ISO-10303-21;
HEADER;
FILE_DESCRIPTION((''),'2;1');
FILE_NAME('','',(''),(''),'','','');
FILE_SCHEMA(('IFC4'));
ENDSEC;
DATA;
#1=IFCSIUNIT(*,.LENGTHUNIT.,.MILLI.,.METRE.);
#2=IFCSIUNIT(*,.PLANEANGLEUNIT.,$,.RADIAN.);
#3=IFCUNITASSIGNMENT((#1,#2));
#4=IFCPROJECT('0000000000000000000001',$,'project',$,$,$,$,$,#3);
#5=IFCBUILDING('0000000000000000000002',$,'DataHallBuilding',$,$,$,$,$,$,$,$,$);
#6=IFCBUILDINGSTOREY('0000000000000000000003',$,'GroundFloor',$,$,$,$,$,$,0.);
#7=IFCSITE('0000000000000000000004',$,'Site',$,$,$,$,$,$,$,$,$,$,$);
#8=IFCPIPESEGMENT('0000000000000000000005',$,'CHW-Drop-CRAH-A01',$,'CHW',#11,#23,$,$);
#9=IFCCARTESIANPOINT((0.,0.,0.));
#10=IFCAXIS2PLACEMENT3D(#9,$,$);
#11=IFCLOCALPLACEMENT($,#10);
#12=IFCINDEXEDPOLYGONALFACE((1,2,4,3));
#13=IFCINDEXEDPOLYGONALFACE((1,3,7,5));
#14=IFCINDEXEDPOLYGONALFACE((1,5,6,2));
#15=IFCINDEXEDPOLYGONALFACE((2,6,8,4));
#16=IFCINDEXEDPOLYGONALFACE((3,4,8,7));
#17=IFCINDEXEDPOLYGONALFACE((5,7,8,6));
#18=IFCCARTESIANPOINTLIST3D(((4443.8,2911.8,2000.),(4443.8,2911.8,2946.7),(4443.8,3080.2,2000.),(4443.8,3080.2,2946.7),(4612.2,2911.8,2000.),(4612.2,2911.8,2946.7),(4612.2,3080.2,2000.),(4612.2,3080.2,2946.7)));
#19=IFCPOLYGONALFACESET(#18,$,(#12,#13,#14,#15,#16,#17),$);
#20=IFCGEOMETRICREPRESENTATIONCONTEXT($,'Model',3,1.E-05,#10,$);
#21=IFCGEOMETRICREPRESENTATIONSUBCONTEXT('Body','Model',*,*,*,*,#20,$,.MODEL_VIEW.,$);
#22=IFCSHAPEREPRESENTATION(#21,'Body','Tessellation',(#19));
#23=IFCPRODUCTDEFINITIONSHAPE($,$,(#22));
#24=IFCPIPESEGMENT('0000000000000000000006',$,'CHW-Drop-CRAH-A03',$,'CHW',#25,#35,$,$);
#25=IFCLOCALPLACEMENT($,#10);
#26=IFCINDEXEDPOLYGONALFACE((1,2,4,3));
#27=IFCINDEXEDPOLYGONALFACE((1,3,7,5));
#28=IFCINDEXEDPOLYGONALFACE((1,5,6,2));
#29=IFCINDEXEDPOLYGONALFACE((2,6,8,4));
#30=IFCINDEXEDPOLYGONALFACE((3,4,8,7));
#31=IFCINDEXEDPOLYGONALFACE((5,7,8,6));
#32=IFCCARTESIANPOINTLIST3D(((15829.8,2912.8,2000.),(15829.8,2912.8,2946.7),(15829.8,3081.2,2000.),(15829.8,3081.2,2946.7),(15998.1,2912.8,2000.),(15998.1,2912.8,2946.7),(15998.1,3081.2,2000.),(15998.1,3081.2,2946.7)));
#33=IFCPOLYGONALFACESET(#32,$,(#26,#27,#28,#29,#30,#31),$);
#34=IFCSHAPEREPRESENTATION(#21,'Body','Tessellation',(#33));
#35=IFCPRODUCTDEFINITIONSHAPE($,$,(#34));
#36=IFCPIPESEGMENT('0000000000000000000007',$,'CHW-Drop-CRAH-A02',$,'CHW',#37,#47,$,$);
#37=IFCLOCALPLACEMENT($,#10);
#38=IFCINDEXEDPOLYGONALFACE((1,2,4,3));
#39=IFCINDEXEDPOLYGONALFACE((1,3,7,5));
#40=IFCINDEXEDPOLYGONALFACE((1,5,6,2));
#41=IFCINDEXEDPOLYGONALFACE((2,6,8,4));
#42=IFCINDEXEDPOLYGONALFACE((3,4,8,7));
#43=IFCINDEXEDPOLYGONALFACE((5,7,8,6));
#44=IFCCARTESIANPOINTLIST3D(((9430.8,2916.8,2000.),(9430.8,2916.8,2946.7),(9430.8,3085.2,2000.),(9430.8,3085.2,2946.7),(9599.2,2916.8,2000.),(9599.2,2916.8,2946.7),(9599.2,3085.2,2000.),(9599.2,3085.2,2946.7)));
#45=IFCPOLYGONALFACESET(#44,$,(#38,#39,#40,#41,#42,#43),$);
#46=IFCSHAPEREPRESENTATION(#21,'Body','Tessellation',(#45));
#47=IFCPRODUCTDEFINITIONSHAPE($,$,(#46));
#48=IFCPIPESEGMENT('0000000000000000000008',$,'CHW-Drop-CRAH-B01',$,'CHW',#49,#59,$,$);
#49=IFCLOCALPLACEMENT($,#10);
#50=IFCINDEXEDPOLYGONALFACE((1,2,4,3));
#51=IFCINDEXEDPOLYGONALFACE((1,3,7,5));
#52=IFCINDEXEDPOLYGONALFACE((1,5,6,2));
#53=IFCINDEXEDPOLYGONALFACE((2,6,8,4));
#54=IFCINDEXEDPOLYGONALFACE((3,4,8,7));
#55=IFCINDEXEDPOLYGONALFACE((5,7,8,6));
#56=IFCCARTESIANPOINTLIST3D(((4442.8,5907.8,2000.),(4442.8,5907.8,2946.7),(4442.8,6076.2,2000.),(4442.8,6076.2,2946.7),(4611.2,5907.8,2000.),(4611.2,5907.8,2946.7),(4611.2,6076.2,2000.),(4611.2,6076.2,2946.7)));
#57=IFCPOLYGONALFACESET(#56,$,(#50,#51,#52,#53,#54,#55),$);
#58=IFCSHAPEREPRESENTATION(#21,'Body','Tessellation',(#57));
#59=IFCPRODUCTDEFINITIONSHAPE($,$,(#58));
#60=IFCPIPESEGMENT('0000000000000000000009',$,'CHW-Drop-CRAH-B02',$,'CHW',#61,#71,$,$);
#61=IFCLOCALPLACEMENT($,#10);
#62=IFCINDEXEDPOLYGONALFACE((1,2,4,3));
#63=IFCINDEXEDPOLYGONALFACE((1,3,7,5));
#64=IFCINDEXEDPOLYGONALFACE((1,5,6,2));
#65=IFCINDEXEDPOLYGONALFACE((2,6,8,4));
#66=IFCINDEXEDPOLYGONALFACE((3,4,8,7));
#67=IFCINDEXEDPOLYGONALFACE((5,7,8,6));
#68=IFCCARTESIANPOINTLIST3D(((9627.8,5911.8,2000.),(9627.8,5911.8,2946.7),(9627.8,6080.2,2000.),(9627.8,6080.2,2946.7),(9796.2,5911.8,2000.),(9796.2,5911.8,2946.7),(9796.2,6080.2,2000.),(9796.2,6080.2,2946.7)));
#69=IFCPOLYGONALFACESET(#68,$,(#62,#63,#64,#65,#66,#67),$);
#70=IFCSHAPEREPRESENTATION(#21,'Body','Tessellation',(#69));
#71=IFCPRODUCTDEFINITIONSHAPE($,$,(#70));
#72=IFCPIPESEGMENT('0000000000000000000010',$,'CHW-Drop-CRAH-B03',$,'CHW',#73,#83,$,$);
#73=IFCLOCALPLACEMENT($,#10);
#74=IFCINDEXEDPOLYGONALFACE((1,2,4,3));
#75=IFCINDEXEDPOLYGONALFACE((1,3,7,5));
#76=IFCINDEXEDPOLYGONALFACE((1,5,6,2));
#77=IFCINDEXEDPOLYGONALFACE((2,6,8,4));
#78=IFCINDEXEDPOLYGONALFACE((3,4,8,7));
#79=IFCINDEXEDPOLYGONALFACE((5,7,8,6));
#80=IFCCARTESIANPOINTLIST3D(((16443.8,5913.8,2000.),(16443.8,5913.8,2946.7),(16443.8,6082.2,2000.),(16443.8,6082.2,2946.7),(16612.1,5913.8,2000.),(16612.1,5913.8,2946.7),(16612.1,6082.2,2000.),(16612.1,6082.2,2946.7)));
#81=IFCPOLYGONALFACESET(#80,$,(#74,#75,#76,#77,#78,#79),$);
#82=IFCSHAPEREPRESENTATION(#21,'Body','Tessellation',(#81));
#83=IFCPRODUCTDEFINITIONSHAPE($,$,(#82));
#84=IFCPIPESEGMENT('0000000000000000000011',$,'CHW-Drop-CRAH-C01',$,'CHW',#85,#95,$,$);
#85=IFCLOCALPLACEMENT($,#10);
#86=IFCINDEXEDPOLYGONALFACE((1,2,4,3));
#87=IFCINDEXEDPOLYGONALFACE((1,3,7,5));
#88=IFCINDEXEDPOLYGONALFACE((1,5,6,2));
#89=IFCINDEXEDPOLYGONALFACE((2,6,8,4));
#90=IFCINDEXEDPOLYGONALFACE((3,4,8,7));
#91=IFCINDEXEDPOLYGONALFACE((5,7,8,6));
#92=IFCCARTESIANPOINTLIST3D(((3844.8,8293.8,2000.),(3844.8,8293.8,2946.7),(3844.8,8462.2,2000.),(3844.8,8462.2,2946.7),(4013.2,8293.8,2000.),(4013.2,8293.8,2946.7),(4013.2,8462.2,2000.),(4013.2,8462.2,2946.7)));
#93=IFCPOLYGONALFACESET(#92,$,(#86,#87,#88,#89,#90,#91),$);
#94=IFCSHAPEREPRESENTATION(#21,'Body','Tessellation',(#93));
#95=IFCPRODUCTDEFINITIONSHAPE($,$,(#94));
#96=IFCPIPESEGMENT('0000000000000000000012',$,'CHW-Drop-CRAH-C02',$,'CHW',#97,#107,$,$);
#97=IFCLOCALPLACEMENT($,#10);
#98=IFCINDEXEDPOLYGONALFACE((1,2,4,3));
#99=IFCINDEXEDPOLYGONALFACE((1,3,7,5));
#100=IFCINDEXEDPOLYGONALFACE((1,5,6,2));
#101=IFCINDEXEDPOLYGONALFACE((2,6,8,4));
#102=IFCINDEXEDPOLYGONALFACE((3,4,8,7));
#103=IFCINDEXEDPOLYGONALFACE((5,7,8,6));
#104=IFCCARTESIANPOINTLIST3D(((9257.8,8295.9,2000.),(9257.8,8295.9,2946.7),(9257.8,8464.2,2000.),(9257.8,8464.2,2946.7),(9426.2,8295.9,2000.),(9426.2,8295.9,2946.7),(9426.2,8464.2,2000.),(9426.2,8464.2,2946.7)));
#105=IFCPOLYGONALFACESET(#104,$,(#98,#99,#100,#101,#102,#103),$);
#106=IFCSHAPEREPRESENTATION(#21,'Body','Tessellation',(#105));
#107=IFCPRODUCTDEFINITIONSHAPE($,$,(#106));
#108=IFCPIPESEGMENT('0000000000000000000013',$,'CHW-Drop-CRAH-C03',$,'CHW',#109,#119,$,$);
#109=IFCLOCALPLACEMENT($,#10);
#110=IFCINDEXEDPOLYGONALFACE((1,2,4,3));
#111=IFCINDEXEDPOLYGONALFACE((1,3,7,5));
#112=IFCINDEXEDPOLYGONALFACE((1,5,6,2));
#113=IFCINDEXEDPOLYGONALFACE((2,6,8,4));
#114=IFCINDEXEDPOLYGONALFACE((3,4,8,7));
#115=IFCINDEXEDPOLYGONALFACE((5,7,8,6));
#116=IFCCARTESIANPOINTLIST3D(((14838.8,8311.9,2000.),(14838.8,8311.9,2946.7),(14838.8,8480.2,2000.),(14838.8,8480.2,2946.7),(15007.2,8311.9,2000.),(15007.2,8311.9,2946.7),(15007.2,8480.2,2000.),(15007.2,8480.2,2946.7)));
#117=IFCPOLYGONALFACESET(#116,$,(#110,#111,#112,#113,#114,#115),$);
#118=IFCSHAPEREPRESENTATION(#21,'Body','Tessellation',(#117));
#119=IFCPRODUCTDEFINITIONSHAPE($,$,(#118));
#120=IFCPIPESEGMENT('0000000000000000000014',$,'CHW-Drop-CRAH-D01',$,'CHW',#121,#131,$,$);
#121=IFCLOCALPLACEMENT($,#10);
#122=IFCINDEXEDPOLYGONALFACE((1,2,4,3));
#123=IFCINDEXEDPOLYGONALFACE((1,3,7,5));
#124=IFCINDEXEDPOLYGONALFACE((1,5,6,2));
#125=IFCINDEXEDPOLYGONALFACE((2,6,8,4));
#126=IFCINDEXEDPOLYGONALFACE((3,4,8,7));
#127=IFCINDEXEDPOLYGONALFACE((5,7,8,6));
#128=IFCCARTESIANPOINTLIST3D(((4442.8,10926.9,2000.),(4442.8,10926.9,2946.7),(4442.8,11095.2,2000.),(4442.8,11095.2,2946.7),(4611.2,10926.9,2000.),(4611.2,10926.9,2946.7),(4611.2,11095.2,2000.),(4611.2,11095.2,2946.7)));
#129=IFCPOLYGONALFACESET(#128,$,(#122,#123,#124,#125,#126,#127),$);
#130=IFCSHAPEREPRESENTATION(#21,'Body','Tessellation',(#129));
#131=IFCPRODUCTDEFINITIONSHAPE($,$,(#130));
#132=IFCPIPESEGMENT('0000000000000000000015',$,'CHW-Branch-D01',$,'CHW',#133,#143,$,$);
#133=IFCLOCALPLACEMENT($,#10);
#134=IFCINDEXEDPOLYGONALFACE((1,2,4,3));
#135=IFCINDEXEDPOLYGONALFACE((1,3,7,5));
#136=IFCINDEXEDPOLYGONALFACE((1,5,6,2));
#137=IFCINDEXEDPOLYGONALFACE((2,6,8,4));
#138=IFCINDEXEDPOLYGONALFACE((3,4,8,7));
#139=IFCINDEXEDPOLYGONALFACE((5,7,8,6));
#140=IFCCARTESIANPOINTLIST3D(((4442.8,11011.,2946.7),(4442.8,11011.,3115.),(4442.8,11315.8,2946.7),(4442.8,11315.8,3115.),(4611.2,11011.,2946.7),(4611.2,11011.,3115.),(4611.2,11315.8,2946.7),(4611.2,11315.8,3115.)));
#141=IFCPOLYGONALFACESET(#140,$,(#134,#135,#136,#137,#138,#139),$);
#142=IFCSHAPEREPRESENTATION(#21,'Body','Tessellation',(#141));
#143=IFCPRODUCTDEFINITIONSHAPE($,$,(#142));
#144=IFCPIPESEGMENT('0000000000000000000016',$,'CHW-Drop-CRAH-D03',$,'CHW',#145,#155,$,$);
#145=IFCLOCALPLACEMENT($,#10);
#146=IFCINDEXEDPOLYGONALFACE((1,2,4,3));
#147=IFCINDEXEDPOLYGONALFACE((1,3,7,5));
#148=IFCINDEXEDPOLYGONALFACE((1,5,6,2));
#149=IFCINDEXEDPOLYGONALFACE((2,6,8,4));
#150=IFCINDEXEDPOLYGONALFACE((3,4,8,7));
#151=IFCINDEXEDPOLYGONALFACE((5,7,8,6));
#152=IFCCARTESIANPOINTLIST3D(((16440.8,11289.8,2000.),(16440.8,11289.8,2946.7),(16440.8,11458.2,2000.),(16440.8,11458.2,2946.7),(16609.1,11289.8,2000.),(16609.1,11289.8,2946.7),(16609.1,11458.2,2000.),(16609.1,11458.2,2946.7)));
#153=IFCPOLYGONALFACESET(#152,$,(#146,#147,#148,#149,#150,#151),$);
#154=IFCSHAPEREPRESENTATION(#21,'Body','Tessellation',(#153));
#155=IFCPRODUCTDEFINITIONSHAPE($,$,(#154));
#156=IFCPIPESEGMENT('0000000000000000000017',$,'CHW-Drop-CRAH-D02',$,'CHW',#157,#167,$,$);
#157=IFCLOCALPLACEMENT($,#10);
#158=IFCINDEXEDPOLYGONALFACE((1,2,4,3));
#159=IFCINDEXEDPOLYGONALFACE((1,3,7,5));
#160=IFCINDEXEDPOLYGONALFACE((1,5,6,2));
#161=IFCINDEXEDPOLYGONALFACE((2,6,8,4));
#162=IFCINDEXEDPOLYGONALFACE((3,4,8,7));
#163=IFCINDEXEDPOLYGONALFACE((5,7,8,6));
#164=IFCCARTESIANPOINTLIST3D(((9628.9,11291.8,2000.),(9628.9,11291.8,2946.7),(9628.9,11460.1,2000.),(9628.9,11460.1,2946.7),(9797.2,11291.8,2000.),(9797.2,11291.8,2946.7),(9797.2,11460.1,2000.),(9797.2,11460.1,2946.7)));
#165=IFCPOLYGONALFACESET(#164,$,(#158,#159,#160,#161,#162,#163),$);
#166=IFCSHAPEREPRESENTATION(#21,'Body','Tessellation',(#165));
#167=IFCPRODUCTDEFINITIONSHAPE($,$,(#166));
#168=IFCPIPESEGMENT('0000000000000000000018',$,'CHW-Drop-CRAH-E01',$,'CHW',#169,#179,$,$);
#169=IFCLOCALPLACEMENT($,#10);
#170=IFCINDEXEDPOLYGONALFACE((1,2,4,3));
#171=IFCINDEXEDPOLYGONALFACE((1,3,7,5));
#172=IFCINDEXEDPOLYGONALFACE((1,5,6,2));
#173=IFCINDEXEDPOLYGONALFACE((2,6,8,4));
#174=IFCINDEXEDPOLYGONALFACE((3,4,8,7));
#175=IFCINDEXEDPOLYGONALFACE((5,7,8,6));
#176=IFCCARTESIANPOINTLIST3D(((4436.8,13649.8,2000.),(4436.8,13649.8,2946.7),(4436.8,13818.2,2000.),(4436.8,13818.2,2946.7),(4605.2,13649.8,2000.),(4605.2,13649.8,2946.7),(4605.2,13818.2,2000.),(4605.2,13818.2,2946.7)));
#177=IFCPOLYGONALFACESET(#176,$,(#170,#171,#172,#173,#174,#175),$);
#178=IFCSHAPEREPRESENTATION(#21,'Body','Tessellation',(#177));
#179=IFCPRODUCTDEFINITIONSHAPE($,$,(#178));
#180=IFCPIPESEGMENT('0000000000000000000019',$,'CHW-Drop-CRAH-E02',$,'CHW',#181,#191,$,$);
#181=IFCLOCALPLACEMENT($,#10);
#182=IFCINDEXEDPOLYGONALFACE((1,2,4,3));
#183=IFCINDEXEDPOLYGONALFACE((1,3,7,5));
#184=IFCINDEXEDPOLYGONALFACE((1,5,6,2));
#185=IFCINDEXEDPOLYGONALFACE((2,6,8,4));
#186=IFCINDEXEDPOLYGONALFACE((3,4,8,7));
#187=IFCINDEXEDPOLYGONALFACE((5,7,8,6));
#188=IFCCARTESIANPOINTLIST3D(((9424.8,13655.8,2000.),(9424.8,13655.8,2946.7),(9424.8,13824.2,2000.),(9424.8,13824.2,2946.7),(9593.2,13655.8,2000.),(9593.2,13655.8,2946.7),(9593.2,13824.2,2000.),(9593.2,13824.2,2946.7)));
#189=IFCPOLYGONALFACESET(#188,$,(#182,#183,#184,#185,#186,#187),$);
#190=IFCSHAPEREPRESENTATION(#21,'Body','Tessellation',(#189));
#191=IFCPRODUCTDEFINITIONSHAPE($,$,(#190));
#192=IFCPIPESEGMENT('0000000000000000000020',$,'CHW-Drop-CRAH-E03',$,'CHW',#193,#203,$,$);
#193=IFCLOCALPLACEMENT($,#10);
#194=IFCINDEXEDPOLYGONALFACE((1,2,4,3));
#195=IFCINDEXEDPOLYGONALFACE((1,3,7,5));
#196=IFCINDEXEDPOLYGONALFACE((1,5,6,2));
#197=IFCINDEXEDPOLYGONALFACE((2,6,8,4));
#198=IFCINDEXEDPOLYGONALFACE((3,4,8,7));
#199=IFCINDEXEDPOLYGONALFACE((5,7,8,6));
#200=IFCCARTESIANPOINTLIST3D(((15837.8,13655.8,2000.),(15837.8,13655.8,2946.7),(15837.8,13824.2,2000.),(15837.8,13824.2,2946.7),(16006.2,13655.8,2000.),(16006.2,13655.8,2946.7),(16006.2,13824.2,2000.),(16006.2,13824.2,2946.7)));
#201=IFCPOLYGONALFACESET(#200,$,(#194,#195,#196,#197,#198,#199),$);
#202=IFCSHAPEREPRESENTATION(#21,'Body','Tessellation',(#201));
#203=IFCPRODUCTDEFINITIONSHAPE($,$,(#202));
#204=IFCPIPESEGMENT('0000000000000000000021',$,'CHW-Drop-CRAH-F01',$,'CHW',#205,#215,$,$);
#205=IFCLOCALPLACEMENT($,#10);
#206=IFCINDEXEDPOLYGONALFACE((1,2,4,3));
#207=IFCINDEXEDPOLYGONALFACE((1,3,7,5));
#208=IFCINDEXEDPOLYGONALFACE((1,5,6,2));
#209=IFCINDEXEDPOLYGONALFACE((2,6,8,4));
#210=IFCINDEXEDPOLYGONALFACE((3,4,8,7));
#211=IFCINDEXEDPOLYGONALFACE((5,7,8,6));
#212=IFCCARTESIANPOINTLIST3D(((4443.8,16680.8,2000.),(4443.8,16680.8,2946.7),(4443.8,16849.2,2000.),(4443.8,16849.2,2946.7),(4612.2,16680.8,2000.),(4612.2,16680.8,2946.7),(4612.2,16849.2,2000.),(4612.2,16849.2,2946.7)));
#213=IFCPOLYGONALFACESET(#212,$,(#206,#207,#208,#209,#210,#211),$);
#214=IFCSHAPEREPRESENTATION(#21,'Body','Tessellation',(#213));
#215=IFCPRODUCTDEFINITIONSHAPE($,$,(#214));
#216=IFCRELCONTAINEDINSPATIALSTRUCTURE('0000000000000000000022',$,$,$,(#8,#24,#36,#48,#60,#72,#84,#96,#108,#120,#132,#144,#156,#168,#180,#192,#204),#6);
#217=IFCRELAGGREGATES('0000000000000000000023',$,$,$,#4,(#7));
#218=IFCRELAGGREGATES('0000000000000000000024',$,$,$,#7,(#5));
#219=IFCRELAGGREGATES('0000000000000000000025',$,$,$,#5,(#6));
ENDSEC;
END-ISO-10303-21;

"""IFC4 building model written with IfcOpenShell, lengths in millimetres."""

from ifc_helpers import new_model, si_unit, frame, origin, place, context, subcontext, project, spatial, rectangle, extrude, element, save


model = new_model("IFC4")

# Units and contexts
model_context = context("Model", 3, precision=1e-05, world=origin())
body_context = subcontext(model_context, "Body", "Model", "MODEL_VIEW")
ifc_project = project(units=[si_unit("LENGTHUNIT", "METRE", prefix="MILLI"), si_unit("PLANEANGLEUNIT", "RADIAN")])

# Site, building, storey
site = spatial("IfcSite", under=ifc_project, Name="Site")
building = spatial("IfcBuilding", under=site, Name="DataHallBuilding")
storey = spatial("IfcBuildingStorey", under=building, Name="GroundFloor", Elevation=0.0)

# Pipe segments
pipe_segment_1_placement = place(None, origin())
element("IfcPipeSegment", 1, at=pipe_segment_1_placement, inside=storey, Name="CHW-Drop-CRAH-A01", ObjectType="CHW", context=body_context, shape_type="SweptSolid", body=[
    extrude(rectangle(XDim=168.3, YDim=168.3), frame((4528.0, 2996.0, 2000.0), z_axis=(0.0, 0.0, 1.0), x_axis=(1.0, 0.0, 0.0)), (0.0, 0.0, 1.0), 946.7),
])
pipe_segment_2_placement = place(None, origin())
element("IfcPipeSegment", 2, at=pipe_segment_2_placement, inside=storey, Name="CHW-Drop-CRAH-A03", ObjectType="CHW", context=body_context, shape_type="SweptSolid", body=[
    extrude(rectangle(XDim=168.3, YDim=168.3), frame((15914.0, 2997.0, 2000.0), z_axis=(0.0, 0.0, 1.0), x_axis=(1.0, 0.0, 0.0)), (0.0, 0.0, 1.0), 946.7),
])
pipe_segment_3_placement = place(None, origin())
element("IfcPipeSegment", 3, at=pipe_segment_3_placement, inside=storey, Name="CHW-Drop-CRAH-A02", ObjectType="CHW", context=body_context, shape_type="SweptSolid", body=[
    extrude(rectangle(XDim=168.3, YDim=168.3), frame((9515.0, 3001.0, 2000.0), z_axis=(0.0, 0.0, 1.0), x_axis=(1.0, 0.0, 0.0)), (0.0, 0.0, 1.0), 946.7),
])
pipe_segment_4_placement = place(None, origin())
element("IfcPipeSegment", 4, at=pipe_segment_4_placement, inside=storey, Name="CHW-Drop-CRAH-B01", ObjectType="CHW", context=body_context, shape_type="SweptSolid", body=[
    extrude(rectangle(XDim=168.3, YDim=168.3), frame((4527.0, 5992.0, 2000.0), z_axis=(0.0, 0.0, 1.0), x_axis=(1.0, 0.0, 0.0)), (0.0, 0.0, 1.0), 946.7),
])
pipe_segment_5_placement = place(None, origin())
element("IfcPipeSegment", 5, at=pipe_segment_5_placement, inside=storey, Name="CHW-Drop-CRAH-B02", ObjectType="CHW", context=body_context, shape_type="SweptSolid", body=[
    extrude(rectangle(XDim=168.3, YDim=168.3), frame((9712.0, 5996.0, 2000.0), z_axis=(0.0, 0.0, 1.0), x_axis=(1.0, 0.0, 0.0)), (0.0, 0.0, 1.0), 946.7),
])
pipe_segment_6_placement = place(None, origin())
element("IfcPipeSegment", 6, at=pipe_segment_6_placement, inside=storey, Name="CHW-Drop-CRAH-B03", ObjectType="CHW", context=body_context, shape_type="SweptSolid", body=[
    extrude(rectangle(XDim=168.3, YDim=168.3), frame((16528.0, 5998.0, 2000.0), z_axis=(0.0, 0.0, 1.0), x_axis=(1.0, 0.0, 0.0)), (0.0, 0.0, 1.0), 946.7),
])
pipe_segment_7_placement = place(None, origin())
element("IfcPipeSegment", 7, at=pipe_segment_7_placement, inside=storey, Name="CHW-Drop-CRAH-C01", ObjectType="CHW", context=body_context, shape_type="SweptSolid", body=[
    extrude(rectangle(XDim=168.3, YDim=168.3), frame((3929.0, 8378.0, 2000.0), z_axis=(0.0, 0.0, 1.0), x_axis=(1.0, 0.0, 0.0)), (0.0, 0.0, 1.0), 946.7),
])
pipe_segment_8_placement = place(None, origin())
element("IfcPipeSegment", 8, at=pipe_segment_8_placement, inside=storey, Name="CHW-Drop-CRAH-C02", ObjectType="CHW", context=body_context, shape_type="SweptSolid", body=[
    extrude(rectangle(XDim=168.3, YDim=168.3), frame((9342.0, 8380.0, 2000.0), z_axis=(0.0, 0.0, 1.0), x_axis=(1.0, 0.0, 0.0)), (0.0, 0.0, 1.0), 946.7),
])
pipe_segment_9_placement = place(None, origin())
element("IfcPipeSegment", 9, at=pipe_segment_9_placement, inside=storey, Name="CHW-Drop-CRAH-C03", ObjectType="CHW", context=body_context, shape_type="SweptSolid", body=[
    extrude(rectangle(XDim=168.3, YDim=168.3), frame((14923.0, 8396.0, 2000.0), z_axis=(0.0, 0.0, 1.0), x_axis=(1.0, 0.0, 0.0)), (0.0, 0.0, 1.0), 946.7),
])
pipe_segment_10_placement = place(None, origin())
element("IfcPipeSegment", 10, at=pipe_segment_10_placement, inside=storey, Name="CHW-Drop-CRAH-D01", ObjectType="CHW", context=body_context, shape_type="SweptSolid", body=[
    extrude(rectangle(XDim=168.3, YDim=168.3), frame((4527.0, 11011.0, 2000.0), z_axis=(0.0, 0.0, 1.0), x_axis=(1.0, 0.0, 0.0)), (0.0, 0.0, 1.0), 946.7),
])
pipe_segment_11_placement = place(None, origin())
element("IfcPipeSegment", 11, at=pipe_segment_11_placement, inside=storey, Name="CHW-Branch-D01", ObjectType="CHW", context=body_context, shape_type="SweptSolid", body=[
    extrude(rectangle(XDim=168.3, YDim=304.9), frame((4527.0, 11163.4, 2946.7), z_axis=(0.0, 0.0, 1.0), x_axis=(1.0, 0.0, 0.0)), (0.0, 0.0, 1.0), 168.3),
])
pipe_segment_12_placement = place(None, origin())
element("IfcPipeSegment", 12, at=pipe_segment_12_placement, inside=storey, Name="CHW-Drop-CRAH-D03", ObjectType="CHW", context=body_context, shape_type="SweptSolid", body=[
    extrude(rectangle(XDim=168.3, YDim=168.3), frame((16525.0, 11374.0, 2000.0), z_axis=(0.0, 0.0, 1.0), x_axis=(1.0, 0.0, 0.0)), (0.0, 0.0, 1.0), 946.7),
])
pipe_segment_13_placement = place(None, origin())
element("IfcPipeSegment", 13, at=pipe_segment_13_placement, inside=storey, Name="CHW-Drop-CRAH-D02", ObjectType="CHW", context=body_context, shape_type="SweptSolid", body=[
    extrude(rectangle(XDim=168.3, YDim=168.3), frame((9713.0, 11376.0, 2000.0), z_axis=(0.0, 0.0, 1.0), x_axis=(1.0, 0.0, 0.0)), (0.0, 0.0, 1.0), 946.7),
])
pipe_segment_14_placement = place(None, origin())
element("IfcPipeSegment", 14, at=pipe_segment_14_placement, inside=storey, Name="CHW-Drop-CRAH-E01", ObjectType="CHW", context=body_context, shape_type="SweptSolid", body=[
    extrude(rectangle(XDim=168.3, YDim=168.3), frame((4521.0, 13734.0, 2000.0), z_axis=(0.0, 0.0, 1.0), x_axis=(1.0, 0.0, 0.0)), (0.0, 0.0, 1.0), 946.7),
])
pipe_segment_15_placement = place(None, origin())
element("IfcPipeSegment", 15, at=pipe_segment_15_placement, inside=storey, Name="CHW-Drop-CRAH-E02", ObjectType="CHW", context=body_context, shape_type="SweptSolid", body=[
    extrude(rectangle(XDim=168.3, YDim=168.3), frame((9509.0, 13740.0, 2000.0), z_axis=(0.0, 0.0, 1.0), x_axis=(1.0, 0.0, 0.0)), (0.0, 0.0, 1.0), 946.7),
])
pipe_segment_16_placement = place(None, origin())
element("IfcPipeSegment", 16, at=pipe_segment_16_placement, inside=storey, Name="CHW-Drop-CRAH-E03", ObjectType="CHW", context=body_context, shape_type="SweptSolid", body=[
    extrude(rectangle(XDim=168.3, YDim=168.3), frame((15922.0, 13740.0, 2000.0), z_axis=(0.0, 0.0, 1.0), x_axis=(1.0, 0.0, 0.0)), (0.0, 0.0, 1.0), 946.7),
])
pipe_segment_17_placement = place(None, origin())
element("IfcPipeSegment", 17, at=pipe_segment_17_placement, inside=storey, Name="CHW-Drop-CRAH-F01", ObjectType="CHW", context=body_context, shape_type="SweptSolid", body=[
    extrude(rectangle(XDim=168.3, YDim=168.3), frame((4528.0, 16765.0, 2000.0), z_axis=(0.0, 0.0, 1.0), x_axis=(1.0, 0.0, 0.0)), (0.0, 0.0, 1.0), 946.7),
])

save(model, "model.ifc")
